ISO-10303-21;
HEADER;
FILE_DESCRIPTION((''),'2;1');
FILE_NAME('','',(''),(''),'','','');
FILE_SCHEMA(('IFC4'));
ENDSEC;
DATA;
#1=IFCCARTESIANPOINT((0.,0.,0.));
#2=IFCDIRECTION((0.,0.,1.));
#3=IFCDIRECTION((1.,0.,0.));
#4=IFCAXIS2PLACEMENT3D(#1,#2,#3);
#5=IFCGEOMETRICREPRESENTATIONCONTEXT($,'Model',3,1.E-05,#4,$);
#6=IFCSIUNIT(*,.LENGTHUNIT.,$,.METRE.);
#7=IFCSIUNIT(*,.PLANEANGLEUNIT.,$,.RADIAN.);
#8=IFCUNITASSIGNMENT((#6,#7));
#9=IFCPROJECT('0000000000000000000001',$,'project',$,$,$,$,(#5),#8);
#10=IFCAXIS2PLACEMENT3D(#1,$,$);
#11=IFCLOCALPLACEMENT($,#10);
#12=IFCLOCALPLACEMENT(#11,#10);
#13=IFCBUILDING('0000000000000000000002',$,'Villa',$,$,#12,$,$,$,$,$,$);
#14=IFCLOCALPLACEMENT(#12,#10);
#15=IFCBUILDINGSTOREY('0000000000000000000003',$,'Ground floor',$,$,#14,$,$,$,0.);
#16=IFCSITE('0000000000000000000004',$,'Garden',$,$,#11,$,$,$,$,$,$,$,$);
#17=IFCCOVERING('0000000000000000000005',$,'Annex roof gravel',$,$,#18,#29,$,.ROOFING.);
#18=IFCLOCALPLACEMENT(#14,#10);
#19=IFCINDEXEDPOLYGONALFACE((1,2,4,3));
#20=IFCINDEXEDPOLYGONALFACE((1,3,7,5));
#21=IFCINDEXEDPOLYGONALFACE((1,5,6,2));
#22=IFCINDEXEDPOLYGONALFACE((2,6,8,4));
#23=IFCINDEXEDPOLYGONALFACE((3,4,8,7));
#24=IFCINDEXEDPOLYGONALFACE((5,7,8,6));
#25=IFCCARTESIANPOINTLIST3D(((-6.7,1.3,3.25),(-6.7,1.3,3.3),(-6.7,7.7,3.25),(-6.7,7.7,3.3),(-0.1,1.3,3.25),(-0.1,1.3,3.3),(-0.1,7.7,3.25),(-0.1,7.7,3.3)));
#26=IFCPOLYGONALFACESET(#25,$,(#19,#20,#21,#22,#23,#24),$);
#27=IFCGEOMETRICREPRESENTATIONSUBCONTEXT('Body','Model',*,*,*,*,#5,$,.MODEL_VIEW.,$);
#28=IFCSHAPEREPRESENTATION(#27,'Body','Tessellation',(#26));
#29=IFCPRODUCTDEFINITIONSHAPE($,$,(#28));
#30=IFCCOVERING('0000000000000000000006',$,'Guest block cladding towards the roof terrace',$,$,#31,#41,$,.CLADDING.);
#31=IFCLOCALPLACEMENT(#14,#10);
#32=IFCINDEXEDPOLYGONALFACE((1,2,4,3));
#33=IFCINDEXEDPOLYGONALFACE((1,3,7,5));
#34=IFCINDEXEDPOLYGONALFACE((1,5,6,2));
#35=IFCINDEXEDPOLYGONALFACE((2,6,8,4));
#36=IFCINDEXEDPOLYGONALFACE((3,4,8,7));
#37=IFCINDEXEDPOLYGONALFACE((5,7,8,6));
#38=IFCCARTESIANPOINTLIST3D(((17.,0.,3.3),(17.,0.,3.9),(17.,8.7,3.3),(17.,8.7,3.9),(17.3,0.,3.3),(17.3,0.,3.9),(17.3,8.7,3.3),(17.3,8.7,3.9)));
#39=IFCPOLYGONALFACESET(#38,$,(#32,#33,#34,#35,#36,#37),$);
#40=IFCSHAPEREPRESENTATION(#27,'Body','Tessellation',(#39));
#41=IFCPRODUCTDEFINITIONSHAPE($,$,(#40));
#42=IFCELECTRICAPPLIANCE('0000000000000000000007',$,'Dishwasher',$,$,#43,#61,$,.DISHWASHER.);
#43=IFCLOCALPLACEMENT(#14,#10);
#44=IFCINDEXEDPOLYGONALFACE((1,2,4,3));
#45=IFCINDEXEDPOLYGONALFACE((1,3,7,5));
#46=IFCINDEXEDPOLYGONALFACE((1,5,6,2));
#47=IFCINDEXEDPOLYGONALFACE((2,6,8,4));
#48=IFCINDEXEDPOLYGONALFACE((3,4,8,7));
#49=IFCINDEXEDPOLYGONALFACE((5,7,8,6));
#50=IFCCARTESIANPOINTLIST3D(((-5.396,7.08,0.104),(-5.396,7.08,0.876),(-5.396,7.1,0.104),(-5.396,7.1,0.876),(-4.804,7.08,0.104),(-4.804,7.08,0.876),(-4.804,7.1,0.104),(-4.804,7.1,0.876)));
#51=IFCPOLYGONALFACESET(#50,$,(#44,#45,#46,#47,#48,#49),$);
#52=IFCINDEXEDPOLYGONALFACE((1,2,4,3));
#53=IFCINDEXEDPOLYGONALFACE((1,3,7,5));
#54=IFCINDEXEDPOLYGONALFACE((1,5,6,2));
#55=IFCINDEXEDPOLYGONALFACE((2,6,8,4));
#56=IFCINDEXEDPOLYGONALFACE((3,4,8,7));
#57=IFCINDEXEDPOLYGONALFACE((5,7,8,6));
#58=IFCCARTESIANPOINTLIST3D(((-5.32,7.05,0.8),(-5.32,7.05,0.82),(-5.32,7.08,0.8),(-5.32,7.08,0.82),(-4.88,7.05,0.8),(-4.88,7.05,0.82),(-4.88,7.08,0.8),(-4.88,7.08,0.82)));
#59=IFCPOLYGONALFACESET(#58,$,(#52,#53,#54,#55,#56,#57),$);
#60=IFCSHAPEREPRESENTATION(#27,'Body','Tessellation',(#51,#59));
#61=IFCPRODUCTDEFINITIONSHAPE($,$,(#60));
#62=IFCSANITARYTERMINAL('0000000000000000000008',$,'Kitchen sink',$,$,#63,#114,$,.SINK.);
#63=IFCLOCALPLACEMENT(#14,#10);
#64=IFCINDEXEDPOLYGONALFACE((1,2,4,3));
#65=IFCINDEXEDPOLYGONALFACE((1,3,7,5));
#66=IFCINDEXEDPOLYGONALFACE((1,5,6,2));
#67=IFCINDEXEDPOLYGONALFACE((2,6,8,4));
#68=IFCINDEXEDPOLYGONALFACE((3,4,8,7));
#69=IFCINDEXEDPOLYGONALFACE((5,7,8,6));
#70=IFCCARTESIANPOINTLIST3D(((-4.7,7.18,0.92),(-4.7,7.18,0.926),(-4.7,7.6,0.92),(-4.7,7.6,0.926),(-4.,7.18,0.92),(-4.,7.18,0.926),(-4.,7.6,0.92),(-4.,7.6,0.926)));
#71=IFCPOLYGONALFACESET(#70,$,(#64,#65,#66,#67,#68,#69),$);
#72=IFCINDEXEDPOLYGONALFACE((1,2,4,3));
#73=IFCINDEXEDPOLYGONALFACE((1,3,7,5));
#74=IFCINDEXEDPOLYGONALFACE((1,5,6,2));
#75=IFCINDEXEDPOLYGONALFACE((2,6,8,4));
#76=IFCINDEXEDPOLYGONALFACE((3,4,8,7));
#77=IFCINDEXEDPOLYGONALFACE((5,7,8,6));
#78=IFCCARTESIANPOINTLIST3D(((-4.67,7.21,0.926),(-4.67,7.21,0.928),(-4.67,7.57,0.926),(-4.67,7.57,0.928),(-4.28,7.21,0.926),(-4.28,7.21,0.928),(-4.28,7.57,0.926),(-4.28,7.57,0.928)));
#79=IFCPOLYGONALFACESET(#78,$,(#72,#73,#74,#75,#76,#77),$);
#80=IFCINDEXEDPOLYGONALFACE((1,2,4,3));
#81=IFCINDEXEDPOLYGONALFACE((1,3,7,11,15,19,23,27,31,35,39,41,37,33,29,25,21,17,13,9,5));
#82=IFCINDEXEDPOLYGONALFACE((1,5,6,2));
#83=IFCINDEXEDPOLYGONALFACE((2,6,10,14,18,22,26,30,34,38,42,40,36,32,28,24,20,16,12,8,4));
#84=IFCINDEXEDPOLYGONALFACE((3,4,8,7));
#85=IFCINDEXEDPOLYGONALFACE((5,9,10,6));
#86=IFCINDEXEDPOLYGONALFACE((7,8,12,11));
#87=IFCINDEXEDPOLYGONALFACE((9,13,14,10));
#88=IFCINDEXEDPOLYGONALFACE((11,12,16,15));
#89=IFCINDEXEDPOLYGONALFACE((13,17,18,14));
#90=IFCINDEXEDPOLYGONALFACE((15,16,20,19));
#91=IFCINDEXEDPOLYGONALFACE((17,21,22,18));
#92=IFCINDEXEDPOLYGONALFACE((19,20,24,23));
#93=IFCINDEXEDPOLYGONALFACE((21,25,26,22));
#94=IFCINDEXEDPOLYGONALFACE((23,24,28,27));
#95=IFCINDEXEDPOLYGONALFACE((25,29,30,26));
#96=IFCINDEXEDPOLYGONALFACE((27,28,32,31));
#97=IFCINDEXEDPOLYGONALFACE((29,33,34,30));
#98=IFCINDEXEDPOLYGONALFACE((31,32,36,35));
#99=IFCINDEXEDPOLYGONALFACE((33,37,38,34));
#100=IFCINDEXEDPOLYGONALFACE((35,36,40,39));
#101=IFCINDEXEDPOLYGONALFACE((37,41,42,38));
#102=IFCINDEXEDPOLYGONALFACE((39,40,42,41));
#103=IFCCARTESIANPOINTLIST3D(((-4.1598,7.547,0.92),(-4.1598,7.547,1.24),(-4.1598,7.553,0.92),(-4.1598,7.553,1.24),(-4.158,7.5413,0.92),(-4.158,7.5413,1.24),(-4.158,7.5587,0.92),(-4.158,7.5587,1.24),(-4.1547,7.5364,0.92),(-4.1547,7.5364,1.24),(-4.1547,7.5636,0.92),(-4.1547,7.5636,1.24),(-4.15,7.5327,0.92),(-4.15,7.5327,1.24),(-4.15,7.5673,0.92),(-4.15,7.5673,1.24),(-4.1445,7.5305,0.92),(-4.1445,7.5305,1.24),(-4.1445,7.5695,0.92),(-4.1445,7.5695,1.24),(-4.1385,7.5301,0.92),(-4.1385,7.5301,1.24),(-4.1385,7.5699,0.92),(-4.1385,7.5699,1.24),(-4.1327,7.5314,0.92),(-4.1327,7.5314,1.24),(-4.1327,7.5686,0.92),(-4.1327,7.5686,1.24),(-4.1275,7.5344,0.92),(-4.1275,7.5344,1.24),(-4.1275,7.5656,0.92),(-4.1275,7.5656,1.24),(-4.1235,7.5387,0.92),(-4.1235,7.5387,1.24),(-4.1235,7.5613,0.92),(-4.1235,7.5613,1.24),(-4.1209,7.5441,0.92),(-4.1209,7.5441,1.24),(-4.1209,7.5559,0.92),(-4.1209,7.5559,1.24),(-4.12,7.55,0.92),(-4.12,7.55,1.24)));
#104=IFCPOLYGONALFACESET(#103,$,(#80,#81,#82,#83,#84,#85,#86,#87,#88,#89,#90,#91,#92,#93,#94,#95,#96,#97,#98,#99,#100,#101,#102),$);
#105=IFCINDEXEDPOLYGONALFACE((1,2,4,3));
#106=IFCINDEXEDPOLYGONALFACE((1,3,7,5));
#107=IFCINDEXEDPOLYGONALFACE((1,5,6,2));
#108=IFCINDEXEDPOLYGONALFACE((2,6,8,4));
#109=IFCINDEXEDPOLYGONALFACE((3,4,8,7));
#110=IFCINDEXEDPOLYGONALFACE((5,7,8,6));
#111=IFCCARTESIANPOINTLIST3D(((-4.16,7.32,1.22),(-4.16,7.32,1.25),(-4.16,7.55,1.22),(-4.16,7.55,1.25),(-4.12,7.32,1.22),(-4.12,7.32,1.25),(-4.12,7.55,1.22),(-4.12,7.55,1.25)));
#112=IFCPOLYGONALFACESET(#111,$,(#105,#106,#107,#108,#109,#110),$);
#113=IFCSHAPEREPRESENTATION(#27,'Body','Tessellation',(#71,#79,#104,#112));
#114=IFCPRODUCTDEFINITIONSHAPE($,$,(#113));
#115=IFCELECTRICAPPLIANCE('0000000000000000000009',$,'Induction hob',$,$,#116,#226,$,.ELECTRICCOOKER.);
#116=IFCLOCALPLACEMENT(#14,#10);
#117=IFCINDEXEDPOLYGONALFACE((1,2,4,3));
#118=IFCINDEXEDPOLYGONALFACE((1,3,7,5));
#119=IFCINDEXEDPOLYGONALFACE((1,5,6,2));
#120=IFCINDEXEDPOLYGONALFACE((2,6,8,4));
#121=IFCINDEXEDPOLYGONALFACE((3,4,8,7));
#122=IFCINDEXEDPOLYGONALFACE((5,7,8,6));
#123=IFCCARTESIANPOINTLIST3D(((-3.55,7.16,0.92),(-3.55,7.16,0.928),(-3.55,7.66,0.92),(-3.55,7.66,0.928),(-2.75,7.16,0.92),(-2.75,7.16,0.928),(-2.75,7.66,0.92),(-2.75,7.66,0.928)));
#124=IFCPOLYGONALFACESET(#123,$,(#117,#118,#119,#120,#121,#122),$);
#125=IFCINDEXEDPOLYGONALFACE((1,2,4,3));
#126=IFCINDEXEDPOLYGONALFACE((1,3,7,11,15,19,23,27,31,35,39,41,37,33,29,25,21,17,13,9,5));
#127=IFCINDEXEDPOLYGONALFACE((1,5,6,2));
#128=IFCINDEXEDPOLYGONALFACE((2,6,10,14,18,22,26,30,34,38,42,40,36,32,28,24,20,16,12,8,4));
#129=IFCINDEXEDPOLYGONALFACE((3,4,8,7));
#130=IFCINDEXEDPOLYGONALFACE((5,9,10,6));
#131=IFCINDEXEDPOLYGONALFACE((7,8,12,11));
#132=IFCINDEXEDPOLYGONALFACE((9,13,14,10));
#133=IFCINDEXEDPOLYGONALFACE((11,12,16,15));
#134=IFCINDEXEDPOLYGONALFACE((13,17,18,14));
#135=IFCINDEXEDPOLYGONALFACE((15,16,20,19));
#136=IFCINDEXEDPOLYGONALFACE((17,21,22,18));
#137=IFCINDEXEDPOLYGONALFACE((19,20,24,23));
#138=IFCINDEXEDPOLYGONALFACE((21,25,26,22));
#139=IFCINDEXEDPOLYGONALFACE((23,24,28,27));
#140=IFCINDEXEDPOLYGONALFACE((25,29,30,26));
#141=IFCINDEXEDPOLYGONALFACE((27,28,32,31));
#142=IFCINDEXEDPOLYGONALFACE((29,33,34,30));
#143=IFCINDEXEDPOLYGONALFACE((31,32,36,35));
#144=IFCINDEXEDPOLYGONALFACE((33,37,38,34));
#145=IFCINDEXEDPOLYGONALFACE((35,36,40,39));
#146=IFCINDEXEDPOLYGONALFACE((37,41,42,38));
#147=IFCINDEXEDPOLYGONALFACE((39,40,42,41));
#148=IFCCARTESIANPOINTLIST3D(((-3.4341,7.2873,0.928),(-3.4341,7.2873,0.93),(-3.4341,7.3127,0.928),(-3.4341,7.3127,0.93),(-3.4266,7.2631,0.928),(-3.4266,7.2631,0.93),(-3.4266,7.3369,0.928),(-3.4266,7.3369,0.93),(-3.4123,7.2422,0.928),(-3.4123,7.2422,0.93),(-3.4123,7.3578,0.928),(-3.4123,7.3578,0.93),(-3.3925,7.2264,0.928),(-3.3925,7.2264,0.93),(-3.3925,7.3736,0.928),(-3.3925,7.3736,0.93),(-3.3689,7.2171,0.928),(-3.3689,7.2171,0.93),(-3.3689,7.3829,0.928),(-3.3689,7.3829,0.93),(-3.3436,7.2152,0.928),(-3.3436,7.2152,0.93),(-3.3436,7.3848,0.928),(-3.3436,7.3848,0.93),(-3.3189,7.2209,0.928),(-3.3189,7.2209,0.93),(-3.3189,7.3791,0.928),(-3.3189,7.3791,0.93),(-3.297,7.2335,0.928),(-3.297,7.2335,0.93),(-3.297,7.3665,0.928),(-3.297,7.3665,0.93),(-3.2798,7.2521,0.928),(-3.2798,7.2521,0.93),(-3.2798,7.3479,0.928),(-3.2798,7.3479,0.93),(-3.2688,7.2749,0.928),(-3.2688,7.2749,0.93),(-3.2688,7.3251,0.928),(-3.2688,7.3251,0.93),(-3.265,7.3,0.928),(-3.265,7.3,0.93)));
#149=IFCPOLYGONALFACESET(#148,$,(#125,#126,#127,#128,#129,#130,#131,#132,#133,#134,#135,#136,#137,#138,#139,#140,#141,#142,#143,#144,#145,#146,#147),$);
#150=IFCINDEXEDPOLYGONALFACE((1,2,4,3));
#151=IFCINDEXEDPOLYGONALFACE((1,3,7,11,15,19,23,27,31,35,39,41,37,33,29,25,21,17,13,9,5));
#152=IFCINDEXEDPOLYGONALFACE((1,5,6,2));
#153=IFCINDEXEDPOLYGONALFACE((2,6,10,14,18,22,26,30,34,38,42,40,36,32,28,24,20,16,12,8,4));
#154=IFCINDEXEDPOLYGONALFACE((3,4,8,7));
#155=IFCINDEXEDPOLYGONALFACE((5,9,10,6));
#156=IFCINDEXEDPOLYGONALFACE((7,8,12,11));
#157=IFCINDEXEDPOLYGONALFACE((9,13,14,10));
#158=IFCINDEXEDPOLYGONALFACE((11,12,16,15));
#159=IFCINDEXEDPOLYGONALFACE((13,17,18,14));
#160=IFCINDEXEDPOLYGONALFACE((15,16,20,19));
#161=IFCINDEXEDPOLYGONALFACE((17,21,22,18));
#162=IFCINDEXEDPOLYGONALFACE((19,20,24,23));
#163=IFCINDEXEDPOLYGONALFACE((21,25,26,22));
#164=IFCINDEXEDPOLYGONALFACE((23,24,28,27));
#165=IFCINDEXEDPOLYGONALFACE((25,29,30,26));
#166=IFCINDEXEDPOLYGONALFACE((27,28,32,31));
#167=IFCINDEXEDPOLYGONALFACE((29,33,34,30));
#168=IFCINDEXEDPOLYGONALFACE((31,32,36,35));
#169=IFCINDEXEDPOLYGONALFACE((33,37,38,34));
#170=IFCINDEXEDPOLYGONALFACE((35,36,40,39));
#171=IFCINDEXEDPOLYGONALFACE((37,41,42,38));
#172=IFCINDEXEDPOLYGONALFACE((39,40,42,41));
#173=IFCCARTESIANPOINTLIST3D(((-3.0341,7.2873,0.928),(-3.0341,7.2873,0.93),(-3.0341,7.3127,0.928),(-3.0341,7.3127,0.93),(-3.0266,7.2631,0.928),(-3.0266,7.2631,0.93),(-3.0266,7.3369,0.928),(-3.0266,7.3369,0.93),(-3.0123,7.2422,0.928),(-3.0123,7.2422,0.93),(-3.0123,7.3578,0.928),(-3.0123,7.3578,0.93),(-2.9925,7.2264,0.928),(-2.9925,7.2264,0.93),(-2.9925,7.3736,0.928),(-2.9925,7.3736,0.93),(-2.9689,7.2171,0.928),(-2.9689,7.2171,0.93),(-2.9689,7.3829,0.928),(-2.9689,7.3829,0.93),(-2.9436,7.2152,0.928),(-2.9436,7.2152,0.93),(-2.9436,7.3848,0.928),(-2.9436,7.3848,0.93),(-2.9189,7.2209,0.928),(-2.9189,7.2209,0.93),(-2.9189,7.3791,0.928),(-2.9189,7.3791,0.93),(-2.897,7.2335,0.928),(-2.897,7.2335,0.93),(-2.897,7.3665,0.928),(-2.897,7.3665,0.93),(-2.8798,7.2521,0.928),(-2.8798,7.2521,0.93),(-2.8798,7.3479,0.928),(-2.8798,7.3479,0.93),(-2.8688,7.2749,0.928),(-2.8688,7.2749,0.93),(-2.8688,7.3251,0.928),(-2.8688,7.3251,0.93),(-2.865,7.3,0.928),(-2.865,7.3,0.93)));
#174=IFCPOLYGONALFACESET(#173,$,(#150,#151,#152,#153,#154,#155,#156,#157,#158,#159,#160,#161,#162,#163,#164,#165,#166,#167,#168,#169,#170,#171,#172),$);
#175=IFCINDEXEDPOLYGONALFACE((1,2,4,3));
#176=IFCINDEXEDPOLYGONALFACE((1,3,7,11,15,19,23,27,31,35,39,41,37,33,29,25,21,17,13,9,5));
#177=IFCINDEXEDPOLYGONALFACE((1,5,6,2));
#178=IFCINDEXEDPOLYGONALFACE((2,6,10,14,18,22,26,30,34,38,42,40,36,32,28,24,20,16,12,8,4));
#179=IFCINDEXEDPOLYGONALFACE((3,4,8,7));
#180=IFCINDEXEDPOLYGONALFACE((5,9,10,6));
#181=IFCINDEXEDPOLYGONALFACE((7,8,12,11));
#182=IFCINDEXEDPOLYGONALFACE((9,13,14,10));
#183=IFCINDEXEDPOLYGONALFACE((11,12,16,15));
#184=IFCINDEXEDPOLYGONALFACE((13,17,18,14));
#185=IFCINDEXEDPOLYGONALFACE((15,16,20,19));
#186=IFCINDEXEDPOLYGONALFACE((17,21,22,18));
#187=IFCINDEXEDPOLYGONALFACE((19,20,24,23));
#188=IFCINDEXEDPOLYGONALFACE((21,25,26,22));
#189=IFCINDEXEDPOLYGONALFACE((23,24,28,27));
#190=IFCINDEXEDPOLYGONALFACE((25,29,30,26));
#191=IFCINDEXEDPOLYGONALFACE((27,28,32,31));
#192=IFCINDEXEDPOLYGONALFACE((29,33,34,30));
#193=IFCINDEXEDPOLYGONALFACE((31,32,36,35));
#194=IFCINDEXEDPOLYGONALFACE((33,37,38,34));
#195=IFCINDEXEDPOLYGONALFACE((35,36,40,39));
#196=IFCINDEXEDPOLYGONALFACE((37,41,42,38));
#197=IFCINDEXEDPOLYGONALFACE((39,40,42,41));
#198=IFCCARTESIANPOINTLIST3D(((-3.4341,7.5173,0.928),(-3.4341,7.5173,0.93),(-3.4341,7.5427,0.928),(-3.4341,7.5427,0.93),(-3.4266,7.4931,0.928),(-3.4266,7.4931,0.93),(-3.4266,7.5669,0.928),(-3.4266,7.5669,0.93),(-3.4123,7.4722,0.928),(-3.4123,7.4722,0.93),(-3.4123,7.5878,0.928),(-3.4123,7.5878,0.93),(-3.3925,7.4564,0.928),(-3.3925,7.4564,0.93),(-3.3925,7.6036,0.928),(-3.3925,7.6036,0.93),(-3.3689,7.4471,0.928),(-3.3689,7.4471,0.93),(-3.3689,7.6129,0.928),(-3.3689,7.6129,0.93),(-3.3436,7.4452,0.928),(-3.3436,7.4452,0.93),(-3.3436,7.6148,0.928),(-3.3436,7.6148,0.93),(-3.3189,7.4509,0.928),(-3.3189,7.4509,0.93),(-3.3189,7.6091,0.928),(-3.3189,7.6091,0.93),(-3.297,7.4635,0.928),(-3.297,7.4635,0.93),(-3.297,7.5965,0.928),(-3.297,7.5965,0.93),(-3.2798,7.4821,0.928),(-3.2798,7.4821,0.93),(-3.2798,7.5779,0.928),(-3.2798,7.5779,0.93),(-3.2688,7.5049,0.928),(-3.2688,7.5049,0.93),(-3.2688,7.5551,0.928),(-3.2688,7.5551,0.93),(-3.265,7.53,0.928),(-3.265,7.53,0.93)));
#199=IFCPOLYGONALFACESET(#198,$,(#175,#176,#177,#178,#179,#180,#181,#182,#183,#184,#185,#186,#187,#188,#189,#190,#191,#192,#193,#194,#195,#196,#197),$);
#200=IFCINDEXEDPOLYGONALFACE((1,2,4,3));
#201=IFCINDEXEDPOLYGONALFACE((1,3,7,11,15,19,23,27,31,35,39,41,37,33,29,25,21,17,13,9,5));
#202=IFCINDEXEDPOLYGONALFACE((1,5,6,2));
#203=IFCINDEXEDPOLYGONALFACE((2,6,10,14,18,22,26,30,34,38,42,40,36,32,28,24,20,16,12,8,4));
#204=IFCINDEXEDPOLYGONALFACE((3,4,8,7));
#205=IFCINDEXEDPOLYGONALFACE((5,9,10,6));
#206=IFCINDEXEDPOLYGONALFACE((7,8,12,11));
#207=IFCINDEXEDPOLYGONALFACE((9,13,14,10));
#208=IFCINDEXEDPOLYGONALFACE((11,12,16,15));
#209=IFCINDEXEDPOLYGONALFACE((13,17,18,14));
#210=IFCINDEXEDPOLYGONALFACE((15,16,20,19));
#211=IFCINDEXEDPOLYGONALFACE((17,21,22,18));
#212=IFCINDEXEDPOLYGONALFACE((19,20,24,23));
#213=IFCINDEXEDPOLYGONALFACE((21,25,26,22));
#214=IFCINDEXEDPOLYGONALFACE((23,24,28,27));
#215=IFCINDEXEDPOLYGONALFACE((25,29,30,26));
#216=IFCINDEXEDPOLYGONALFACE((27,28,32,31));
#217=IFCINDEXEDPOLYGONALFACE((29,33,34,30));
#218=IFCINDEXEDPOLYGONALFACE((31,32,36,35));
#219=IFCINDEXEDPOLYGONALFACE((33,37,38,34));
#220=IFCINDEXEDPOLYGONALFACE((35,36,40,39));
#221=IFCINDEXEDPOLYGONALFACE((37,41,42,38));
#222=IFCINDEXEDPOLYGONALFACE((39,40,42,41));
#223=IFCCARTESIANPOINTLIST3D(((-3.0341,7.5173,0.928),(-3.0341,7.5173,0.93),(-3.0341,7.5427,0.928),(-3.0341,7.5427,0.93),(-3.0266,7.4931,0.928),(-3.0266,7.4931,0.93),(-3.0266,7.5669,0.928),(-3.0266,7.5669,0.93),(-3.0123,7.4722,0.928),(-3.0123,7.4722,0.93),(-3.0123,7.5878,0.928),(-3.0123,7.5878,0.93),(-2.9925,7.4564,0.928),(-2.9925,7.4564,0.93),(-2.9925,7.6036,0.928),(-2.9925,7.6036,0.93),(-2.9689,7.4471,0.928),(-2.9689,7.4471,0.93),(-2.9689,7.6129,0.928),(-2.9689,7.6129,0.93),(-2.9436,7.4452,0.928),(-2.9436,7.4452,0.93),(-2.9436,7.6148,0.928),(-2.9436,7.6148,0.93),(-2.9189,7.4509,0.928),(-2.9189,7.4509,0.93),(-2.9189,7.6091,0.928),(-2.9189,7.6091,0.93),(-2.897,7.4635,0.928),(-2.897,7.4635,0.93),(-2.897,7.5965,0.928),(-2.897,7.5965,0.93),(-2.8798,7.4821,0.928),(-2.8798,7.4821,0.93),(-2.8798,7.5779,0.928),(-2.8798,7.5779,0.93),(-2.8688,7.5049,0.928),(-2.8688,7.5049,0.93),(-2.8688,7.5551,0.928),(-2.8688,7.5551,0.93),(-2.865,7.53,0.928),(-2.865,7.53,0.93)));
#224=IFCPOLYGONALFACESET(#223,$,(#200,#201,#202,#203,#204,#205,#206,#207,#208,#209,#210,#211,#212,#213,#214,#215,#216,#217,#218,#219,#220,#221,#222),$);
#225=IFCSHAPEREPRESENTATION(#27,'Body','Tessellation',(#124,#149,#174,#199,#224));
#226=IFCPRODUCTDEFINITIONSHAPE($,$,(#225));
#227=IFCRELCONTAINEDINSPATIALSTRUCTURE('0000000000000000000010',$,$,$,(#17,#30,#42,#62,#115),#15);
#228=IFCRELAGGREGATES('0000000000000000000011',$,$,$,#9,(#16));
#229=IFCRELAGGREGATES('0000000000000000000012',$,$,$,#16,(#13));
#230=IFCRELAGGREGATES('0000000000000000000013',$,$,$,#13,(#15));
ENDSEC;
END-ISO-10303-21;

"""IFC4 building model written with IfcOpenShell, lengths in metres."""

from ifc_helpers import new_model, si_unit, frame, frame_2d, origin, origin_with_axes, place, context, subcontext, project, spatial, rectangle, circle, extrude, element, save


model = new_model("IFC4")

# Units and contexts
model_context = context("Model", 3, precision=1e-05, world=origin_with_axes())
body_context = subcontext(model_context, "Body", "Model", "MODEL_VIEW")
ifc_project = project(units=[si_unit("LENGTHUNIT", "METRE"), si_unit("PLANEANGLEUNIT", "RADIAN")], contexts=[model_context])

# Site, building, storey
site_placement = place(None, origin())
site = spatial("IfcSite", under=ifc_project, at=site_placement, Name="Garden")
building_placement = place(site_placement, origin())
building = spatial("IfcBuilding", under=site, at=building_placement, Name="Villa")
storey_placement = place(building_placement, origin())
storey = spatial("IfcBuildingStorey", under=building, at=storey_placement, Name="Ground floor", Elevation=0.0)

# Coverings
covering_1_placement = place(storey_placement, origin())
element("IfcCovering", 1, at=covering_1_placement, inside=storey, Name="Annex roof gravel", PredefinedType="ROOFING", context=body_context, shape_type="SweptSolid", body=[
    extrude(rectangle(XDim=6.6, YDim=6.4, at=frame_2d((3.3, 3.2))), frame((-6.7, 1.3, 3.25)), (0.0, 0.0, 1.0), 0.05),
])
covering_2_placement = place(storey_placement, origin())
element("IfcCovering", 2, at=covering_2_placement, inside=storey, Name="Guest block cladding towards the roof terrace", PredefinedType="CLADDING", context=body_context, shape_type="SweptSolid", body=[
    extrude(rectangle(XDim=0.3, YDim=8.7, at=frame_2d((0.15, 4.35))), frame((17.0, 0.0, 3.3)), (0.0, 0.0, 1.0), 0.6),
])

# Electric appliance
electric_appliance_1_placement = place(storey_placement, frame((-6.6, 7.08, 0.0)))
element("IfcElectricAppliance", 3, at=electric_appliance_1_placement, inside=storey, Name="Dishwasher", PredefinedType="DISHWASHER", context=body_context, shape_type="SweptSolid", body=[
    extrude(rectangle(XDim=0.592, YDim=0.02, at=frame_2d((0.296, 0.01))), frame((1.204, 0.0, 0.104)), (0.0, 0.0, 1.0), 0.772),
    extrude(rectangle(XDim=0.44, YDim=0.03, at=frame_2d((0.22, 0.015))), frame((1.28, -0.03, 0.8)), (0.0, 0.0, 1.0), 0.02),
])

# Sanitary terminal
sanitary_terminal_placement = place(storey_placement, frame((-4.7, 7.18, 0.92)))
element("IfcSanitaryTerminal", 4, at=sanitary_terminal_placement, inside=storey, Name="Kitchen sink", PredefinedType="SINK", context=body_context, shape_type="SweptSolid", body=[
    extrude(rectangle(XDim=0.7, YDim=0.42, at=frame_2d((0.35, 0.21))), origin(), (0.0, 0.0, 1.0), 0.006),
    extrude(rectangle(XDim=0.39, YDim=0.36, at=frame_2d((0.195, 0.18))), frame((0.03, 0.03, 0.006)), (0.0, 0.0, 1.0), 0.002),
    extrude(circle(Radius=0.02, at=frame_2d((0.56, 0.37))), origin(), (0.0, 0.0, 1.0), 0.32),
    extrude(rectangle(XDim=0.04, YDim=0.23, at=frame_2d((0.02, 0.115))), frame((0.54, 0.14, 0.3)), (0.0, 0.0, 1.0), 0.03),
])

# Electric appliance
electric_appliance_2_placement = place(storey_placement, frame((-3.55, 7.16, 0.92)))
element("IfcElectricAppliance", 5, at=electric_appliance_2_placement, inside=storey, Name="Induction hob", PredefinedType="ELECTRICCOOKER", context=body_context, shape_type="SweptSolid", body=[
    extrude(rectangle(XDim=0.8, YDim=0.5, at=frame_2d((0.4, 0.25))), origin(), (0.0, 0.0, 1.0), 0.008),
    extrude(circle(Radius=0.085, at=frame_2d((0.2, 0.14))), frame((0.0, 0.0, 0.008)), (0.0, 0.0, 1.0), 0.002),
    extrude(circle(Radius=0.085, at=frame_2d((0.6, 0.14))), frame((0.0, 0.0, 0.008)), (0.0, 0.0, 1.0), 0.002),
    extrude(circle(Radius=0.085, at=frame_2d((0.2, 0.37))), frame((0.0, 0.0, 0.008)), (0.0, 0.0, 1.0), 0.002),
    extrude(circle(Radius=0.085, at=frame_2d((0.6, 0.37))), frame((0.0, 0.0, 0.008)), (0.0, 0.0, 1.0), 0.002),
])

save(model, "model.ifc")
